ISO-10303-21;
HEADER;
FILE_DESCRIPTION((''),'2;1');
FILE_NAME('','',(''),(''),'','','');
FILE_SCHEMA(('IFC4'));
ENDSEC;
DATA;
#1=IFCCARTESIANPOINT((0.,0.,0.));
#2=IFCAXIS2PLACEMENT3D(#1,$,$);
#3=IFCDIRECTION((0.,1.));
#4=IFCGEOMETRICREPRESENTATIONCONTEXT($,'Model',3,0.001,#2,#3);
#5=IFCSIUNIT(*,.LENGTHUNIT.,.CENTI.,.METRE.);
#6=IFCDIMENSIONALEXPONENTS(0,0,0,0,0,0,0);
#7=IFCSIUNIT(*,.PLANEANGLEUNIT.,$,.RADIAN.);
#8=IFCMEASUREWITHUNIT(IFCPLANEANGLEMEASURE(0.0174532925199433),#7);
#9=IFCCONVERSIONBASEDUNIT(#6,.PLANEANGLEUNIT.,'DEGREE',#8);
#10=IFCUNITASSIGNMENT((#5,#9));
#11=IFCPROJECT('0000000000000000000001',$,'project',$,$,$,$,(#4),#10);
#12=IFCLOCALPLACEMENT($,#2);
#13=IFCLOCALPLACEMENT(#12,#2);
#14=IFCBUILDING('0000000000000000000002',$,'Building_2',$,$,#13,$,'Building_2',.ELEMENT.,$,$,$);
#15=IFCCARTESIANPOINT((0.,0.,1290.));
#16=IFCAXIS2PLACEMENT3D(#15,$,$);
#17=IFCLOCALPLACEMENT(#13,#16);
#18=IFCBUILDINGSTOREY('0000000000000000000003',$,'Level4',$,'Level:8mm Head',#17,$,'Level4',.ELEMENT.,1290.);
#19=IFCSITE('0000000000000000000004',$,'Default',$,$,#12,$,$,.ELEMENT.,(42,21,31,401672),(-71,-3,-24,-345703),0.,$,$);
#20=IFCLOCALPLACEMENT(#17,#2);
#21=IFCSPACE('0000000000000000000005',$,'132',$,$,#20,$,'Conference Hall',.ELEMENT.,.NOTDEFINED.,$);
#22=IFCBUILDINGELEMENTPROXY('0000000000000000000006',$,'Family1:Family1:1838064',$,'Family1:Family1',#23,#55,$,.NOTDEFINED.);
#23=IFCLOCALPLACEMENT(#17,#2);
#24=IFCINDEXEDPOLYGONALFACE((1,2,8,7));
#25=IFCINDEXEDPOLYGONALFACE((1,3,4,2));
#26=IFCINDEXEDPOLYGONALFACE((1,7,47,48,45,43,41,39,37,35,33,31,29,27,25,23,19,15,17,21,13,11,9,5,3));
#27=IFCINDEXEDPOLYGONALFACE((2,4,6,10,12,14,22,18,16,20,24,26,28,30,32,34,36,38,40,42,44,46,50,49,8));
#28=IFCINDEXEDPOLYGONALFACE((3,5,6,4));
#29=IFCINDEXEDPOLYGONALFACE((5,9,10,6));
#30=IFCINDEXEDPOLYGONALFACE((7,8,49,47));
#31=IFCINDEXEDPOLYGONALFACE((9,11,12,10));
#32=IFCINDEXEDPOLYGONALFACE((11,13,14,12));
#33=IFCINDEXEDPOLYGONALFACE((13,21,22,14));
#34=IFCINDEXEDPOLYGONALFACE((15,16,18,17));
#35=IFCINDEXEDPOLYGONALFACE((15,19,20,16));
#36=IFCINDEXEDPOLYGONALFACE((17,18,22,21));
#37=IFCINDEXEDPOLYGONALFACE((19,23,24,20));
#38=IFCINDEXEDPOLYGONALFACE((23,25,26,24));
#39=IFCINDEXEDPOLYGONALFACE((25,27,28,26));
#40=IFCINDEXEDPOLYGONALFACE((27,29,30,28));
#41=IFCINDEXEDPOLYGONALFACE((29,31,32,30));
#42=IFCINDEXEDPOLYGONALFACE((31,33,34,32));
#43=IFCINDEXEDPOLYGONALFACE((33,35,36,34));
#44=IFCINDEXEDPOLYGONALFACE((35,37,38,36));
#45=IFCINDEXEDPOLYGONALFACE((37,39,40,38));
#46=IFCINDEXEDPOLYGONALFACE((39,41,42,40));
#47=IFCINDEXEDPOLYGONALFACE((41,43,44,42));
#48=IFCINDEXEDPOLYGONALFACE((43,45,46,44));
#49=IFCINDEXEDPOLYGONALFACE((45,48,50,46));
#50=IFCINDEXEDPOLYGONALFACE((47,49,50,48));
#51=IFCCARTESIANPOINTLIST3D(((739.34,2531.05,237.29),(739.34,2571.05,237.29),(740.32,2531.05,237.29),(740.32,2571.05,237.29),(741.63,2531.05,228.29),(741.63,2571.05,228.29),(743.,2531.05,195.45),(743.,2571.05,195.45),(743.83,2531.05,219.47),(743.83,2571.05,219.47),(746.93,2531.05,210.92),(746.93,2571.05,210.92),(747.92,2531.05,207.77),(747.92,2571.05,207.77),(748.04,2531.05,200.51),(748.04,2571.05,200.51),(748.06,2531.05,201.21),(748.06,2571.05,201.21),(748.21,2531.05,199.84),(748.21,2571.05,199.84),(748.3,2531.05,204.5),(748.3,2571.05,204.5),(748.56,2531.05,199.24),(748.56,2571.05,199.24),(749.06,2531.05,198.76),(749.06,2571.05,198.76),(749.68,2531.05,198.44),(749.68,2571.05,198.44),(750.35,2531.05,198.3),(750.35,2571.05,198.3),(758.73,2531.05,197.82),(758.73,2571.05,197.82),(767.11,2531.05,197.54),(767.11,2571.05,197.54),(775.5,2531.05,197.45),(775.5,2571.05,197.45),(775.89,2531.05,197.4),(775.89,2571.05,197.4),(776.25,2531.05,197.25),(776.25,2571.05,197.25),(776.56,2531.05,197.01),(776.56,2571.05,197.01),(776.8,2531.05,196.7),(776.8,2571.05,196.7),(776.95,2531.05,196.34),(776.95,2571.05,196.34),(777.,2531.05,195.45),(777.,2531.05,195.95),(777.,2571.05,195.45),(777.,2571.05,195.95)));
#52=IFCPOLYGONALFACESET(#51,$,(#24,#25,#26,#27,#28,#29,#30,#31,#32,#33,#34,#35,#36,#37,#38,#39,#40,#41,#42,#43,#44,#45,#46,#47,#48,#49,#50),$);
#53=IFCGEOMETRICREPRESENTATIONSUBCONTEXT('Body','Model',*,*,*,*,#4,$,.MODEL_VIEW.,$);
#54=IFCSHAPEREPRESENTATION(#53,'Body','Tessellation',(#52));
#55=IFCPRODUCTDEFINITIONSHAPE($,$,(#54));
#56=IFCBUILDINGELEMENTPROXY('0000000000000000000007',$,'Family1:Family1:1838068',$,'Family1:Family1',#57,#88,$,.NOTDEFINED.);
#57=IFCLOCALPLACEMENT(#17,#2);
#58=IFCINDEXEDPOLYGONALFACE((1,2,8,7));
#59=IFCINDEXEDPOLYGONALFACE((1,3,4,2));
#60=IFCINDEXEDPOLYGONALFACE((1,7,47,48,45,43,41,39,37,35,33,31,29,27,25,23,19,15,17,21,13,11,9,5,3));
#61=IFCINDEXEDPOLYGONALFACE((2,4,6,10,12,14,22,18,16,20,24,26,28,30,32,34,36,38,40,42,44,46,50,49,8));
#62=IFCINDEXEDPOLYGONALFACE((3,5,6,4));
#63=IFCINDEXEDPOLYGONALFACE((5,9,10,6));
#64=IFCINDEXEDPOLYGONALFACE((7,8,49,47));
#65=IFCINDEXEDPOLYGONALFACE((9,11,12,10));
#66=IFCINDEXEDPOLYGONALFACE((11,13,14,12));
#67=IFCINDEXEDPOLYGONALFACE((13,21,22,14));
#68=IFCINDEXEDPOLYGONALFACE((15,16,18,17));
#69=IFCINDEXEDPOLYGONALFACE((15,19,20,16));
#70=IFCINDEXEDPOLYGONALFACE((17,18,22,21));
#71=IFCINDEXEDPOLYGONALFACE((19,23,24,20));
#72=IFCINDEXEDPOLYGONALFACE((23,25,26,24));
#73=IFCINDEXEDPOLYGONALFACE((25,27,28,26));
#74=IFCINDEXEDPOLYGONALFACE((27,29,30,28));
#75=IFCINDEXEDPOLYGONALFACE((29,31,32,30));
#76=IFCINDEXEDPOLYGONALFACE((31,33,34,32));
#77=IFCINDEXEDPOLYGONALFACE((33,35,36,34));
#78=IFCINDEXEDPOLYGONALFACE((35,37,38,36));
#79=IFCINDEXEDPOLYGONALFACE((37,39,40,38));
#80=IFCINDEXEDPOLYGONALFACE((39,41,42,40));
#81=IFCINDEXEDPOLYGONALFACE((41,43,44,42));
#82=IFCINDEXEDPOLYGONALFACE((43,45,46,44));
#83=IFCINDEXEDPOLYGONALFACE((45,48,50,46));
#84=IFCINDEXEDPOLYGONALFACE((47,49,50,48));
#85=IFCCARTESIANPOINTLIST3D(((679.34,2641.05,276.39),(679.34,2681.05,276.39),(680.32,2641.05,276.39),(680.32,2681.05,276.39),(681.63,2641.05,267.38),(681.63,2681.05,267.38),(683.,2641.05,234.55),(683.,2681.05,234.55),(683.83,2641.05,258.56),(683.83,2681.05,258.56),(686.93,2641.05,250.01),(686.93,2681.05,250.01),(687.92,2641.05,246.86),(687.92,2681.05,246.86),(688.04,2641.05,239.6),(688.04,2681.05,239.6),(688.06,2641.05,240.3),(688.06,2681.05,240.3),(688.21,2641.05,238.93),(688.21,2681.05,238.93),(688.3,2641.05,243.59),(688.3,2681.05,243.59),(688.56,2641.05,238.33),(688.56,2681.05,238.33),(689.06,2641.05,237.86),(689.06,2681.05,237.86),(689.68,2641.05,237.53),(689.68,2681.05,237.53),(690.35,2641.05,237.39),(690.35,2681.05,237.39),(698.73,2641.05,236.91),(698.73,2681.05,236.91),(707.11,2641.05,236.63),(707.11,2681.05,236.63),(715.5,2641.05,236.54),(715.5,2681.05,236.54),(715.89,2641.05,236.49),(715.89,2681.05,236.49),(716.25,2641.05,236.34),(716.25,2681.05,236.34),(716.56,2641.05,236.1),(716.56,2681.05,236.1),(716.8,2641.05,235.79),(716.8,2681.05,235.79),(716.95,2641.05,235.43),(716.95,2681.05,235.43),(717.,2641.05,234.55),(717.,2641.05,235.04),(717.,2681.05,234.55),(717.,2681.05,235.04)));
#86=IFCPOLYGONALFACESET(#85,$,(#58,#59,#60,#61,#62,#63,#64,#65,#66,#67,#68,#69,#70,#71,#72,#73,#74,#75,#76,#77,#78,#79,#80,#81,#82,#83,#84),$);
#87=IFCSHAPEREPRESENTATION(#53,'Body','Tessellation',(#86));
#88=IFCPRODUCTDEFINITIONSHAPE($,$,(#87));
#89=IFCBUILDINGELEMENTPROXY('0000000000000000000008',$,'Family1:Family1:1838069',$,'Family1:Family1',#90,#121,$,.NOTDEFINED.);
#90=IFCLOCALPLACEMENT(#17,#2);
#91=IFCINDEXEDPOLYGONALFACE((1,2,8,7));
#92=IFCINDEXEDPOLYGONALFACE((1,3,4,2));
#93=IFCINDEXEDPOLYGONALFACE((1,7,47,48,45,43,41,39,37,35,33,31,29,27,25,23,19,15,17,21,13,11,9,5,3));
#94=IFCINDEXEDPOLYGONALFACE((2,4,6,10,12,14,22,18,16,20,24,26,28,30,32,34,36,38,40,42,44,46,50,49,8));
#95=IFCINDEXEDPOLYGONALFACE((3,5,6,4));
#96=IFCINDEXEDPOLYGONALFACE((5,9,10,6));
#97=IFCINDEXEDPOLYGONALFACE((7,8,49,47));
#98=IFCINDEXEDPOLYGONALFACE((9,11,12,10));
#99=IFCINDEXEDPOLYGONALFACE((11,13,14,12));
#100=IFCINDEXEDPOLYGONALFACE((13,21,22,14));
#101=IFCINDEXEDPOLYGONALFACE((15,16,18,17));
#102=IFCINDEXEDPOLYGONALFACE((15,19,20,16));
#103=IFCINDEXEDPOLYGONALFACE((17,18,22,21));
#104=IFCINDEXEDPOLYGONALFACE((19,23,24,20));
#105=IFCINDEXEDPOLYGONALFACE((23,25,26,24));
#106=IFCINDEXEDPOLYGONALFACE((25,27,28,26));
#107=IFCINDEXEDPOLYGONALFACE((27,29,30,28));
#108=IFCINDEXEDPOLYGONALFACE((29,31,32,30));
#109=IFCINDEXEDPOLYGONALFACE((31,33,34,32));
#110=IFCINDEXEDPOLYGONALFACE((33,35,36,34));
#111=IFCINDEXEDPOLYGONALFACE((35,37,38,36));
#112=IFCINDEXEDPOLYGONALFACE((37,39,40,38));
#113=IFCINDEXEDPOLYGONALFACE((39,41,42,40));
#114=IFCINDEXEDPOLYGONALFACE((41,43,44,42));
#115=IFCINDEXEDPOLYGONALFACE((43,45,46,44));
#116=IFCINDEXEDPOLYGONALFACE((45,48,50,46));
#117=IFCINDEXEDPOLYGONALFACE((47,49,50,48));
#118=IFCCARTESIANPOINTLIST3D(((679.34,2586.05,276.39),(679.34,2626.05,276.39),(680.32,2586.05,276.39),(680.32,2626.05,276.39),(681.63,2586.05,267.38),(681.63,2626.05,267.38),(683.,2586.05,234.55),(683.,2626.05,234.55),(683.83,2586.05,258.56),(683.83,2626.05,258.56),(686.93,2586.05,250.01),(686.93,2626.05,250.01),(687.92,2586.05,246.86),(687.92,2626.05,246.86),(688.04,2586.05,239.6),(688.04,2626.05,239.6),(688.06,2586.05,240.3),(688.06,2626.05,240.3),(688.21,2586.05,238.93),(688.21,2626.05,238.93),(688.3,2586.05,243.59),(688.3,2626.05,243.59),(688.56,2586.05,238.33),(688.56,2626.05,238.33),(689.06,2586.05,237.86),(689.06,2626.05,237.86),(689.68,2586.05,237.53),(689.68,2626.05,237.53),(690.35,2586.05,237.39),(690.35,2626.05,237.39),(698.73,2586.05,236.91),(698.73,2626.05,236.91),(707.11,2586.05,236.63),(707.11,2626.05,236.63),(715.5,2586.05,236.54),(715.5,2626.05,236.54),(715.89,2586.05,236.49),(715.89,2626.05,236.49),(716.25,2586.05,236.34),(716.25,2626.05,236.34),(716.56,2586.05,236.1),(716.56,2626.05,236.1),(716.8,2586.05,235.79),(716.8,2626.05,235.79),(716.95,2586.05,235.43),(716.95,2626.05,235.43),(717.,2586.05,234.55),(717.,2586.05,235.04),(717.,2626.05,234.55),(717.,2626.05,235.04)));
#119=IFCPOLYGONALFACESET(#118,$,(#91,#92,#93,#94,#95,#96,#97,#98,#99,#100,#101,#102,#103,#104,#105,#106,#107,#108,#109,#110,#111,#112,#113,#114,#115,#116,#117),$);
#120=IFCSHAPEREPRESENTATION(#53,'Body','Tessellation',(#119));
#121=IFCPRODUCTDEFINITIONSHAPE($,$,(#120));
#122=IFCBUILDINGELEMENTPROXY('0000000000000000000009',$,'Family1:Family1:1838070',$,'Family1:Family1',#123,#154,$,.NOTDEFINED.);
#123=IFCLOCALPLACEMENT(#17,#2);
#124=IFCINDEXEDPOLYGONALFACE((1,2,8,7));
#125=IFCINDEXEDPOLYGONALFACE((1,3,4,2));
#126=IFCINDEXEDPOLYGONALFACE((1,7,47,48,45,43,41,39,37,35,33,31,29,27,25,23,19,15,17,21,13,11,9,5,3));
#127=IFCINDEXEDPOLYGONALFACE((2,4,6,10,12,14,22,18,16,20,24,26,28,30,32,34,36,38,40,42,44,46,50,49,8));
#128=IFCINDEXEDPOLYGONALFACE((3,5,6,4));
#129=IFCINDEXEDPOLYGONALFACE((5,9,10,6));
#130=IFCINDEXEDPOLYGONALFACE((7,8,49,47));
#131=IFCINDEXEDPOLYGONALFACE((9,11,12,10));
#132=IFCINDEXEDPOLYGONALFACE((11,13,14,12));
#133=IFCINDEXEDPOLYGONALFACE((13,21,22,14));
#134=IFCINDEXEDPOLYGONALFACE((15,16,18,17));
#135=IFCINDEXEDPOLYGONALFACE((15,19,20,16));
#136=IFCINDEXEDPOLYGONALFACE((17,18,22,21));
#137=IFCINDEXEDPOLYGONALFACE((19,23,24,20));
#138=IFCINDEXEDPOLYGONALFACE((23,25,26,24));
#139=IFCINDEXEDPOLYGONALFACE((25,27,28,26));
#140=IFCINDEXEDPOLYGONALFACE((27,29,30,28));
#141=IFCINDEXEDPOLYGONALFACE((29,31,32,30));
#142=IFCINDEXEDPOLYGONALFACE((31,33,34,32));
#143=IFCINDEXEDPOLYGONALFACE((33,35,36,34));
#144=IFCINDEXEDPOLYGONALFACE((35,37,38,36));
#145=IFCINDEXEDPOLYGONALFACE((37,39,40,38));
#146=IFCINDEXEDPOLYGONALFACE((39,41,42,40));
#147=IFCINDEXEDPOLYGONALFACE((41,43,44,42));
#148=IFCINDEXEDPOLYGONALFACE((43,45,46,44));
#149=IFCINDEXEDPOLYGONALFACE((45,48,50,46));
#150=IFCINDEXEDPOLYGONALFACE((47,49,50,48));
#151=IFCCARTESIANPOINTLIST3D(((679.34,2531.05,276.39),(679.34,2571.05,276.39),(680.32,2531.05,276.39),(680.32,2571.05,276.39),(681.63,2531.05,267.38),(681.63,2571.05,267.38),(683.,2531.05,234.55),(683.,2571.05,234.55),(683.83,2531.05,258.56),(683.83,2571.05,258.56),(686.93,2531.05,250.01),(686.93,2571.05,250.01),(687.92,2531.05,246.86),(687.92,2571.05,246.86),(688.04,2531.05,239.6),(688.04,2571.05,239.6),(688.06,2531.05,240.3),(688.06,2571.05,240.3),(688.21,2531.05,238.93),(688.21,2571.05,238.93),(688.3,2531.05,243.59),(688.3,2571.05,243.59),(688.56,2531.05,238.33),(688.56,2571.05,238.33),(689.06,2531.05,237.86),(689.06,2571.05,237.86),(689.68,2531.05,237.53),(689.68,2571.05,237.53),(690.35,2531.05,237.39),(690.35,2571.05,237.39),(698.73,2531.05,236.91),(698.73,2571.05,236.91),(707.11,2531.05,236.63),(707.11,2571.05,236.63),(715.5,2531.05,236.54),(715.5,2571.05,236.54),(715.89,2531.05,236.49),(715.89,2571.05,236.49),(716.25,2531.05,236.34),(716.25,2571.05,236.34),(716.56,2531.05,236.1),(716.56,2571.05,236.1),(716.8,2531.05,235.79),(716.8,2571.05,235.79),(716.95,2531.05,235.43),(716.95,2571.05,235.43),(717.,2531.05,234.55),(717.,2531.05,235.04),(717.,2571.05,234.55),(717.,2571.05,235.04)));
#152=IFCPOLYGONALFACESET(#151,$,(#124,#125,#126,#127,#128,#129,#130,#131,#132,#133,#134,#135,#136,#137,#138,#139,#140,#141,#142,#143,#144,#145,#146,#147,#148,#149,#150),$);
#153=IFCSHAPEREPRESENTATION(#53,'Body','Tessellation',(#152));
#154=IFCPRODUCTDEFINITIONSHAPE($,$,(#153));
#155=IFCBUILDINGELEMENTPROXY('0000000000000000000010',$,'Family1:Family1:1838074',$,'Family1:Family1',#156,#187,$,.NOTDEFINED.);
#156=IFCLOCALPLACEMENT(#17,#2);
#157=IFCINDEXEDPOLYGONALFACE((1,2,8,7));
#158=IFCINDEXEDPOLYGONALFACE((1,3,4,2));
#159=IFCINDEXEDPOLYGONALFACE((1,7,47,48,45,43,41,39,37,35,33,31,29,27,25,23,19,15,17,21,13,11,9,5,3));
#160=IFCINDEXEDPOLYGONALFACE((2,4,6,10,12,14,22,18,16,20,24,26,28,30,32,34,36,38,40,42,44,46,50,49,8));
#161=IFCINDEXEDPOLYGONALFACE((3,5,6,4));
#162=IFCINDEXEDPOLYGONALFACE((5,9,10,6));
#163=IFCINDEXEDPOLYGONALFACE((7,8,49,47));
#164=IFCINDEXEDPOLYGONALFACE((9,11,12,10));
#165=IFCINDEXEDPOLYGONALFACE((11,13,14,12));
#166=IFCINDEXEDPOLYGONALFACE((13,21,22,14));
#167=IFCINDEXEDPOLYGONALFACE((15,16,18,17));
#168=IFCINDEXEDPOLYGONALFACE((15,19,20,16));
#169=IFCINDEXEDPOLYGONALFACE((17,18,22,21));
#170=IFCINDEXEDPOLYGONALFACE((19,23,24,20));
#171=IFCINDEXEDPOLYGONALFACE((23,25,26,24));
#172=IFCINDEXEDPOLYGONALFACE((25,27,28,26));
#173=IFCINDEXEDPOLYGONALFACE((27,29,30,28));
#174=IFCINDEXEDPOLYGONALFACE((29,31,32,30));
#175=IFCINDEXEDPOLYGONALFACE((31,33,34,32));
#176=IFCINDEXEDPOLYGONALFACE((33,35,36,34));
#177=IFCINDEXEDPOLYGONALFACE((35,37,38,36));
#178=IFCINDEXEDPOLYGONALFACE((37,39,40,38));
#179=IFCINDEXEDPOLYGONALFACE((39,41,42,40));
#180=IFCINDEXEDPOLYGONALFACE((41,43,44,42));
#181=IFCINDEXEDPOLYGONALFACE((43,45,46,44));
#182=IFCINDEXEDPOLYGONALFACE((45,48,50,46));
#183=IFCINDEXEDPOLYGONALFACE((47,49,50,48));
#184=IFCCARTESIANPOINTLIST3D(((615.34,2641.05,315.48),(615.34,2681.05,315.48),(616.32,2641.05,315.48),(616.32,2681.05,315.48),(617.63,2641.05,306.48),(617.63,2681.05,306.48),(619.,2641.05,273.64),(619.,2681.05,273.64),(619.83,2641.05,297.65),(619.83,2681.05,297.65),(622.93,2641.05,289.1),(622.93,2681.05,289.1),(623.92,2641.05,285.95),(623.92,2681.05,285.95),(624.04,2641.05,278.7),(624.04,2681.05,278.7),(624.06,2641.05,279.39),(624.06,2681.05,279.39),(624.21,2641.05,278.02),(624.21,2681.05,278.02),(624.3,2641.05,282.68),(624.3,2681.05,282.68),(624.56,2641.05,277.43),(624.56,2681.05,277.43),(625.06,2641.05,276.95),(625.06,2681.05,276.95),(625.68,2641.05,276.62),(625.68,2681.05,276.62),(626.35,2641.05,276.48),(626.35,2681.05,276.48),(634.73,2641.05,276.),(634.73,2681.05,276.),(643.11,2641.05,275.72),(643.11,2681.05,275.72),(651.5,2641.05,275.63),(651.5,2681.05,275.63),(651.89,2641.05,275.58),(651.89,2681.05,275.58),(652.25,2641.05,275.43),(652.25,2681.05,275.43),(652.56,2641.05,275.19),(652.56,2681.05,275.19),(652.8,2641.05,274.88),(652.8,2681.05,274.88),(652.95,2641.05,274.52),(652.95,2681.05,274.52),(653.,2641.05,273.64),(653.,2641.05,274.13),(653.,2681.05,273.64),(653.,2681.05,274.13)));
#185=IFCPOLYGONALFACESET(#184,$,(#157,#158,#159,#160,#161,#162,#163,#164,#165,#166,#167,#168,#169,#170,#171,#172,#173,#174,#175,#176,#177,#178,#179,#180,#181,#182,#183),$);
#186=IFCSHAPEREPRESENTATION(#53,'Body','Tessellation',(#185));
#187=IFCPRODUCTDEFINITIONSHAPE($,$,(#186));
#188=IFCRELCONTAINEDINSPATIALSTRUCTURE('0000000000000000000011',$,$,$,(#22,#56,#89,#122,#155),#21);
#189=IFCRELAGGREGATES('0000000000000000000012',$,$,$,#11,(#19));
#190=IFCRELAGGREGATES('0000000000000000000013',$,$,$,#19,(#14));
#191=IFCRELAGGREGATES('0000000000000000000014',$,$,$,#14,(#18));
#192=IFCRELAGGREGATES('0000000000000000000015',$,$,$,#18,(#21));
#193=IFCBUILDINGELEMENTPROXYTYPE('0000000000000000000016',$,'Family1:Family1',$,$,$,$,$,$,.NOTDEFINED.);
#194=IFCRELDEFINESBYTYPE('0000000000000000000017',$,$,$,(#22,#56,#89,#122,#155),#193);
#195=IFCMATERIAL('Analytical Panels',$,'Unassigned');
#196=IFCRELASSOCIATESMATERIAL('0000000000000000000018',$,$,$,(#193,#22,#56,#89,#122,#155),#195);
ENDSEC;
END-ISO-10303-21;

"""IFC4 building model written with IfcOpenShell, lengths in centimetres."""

from ifc_helpers import new_model, entity, si_unit, converted_unit, direction, frame, origin, place, context, subcontext, project, spatial, line, arc, indexed_curve, outline, extrude, source, transform, mapped, material, type_object, type_shapes, element, save


model = new_model("IFC4")

# Units and contexts
model_context = context("Model", 3, precision=0.001, world=origin(), true_north=direction((0.0, 1.0)))
body_context = subcontext(model_context, "Body", "Model", "MODEL_VIEW")
ifc_project = project(units=[si_unit("LENGTHUNIT", "METRE", prefix="CENTI"), converted_unit("PLANEANGLEUNIT", "DEGREE", entity("IfcPlaneAngleMeasure", 0.0174532925199433), si_unit("PLANEANGLEUNIT", "RADIAN"), dimensions=[0, 0, 0, 0, 0, 0, 0])], contexts=[model_context])

# Site, building, storey
site_placement = place(None, origin())
site = spatial("IfcSite", under=ifc_project, at=site_placement, Name="Default", CompositionType="ELEMENT", RefLatitude=(42, 21, 31, 401672), RefLongitude=(-71, -3, -24, -345703), RefElevation=0.0)
building_placement = place(site_placement, origin())
building = spatial("IfcBuilding", under=site, at=building_placement, Name="Building_2", LongName="Building_2", CompositionType="ELEMENT")
storey_placement = place(building_placement, frame((0.0, 0.0, 1290.0)))
storey = spatial("IfcBuildingStorey", under=building, at=storey_placement, Name="Level4", ObjectType="Level:8mm Head", LongName="Level4", CompositionType="ELEMENT", Elevation=1290.0)

# Shared definitions
space_1_placement = place(storey_placement, origin())
space_1 = spatial("IfcSpace", under=storey, at=space_1_placement, Name="132", LongName="Conference Hall", CompositionType="ELEMENT", PredefinedType="NOTDEFINED")

# Building element proxies
ifc_material_1 = material(Name="Analytical Panels", Category="Unassigned")
building_element_proxy_type_1 = type_object("IfcBuildingElementProxyType", Name="Family1:Family1", PredefinedType="NOTDEFINED", material=ifc_material_1)
shared_shape_1 = source(origin(), body_context, "Body", "SweptSolid", [
    extrude(outline(indexed_curve([(-11.13, -13.3), (30.87, -13.3), (30.78, -12.32), (17.19, -11.21), (3.93, -8.04), (-0.94, -7.2), (-5.84, -7.76), (-7.84, -7.43), (-8.94, -5.73), (-10.68, 6.74), (-11.98, 19.25), (-12.51, 20.27), (-13.6, 20.61), (-14.09, 20.57)], segments=[line(1, 2, 3), arc(3, 4, 5), arc(5, 6, 7), arc(7, 8, 9), arc(9, 10, 11), arc(11, 12, 13), line(13, 14, 1)], self_intersect=False)), frame((-20.0, 6.72, 12.25), z_axis=(1.0, 0.0, 0.0), x_axis=(0.0, 0.087156, 0.996195)), (0.0, 0.0, 1.0), 40.0),
])
type_shapes(building_element_proxy_type_1, [shared_shape_1])
for number, where, z_axis, x_axis, name in (
    (1, (762.0, 2551.05, 195.45), (0.0, 0.0, 1.0), (0.0, 1.0, 0.0), "Family1:Family1:1838064"),
    (2, (702.0, 2661.05, 234.55), (0.0, 0.0, 1.0), (0.0, 1.0, 0.0), "Family1:Family1:1838068"),
    (3, (702.0, 2606.05, 234.55), (0.0, 0.0, 1.0), (0.0, 1.0, 0.0), "Family1:Family1:1838069"),
    (4, (702.0, 2551.05, 234.55), (0.0, 0.0, 1.0), (0.0, 1.0, 0.0), "Family1:Family1:1838070"),
    (5, (638.0, 2661.05, 273.64), (0.0, 0.0, 1.0), (0.0, 1.0, 0.0), "Family1:Family1:1838074"),
):
    element("IfcBuildingElementProxy", number, at=place(space_1_placement, frame(where, z_axis=z_axis, x_axis=x_axis)), inside=space_1, type_object=building_element_proxy_type_1, material=ifc_material_1, Name=name, ObjectType="Family1:Family1", PredefinedType="NOTDEFINED", context=body_context, shape_type="MappedRepresentation", body=[
        mapped(shared_shape_1, transform((0.0, 0.0, 0.0), scale=1.0)),
    ])

save(model, "model.ifc")
